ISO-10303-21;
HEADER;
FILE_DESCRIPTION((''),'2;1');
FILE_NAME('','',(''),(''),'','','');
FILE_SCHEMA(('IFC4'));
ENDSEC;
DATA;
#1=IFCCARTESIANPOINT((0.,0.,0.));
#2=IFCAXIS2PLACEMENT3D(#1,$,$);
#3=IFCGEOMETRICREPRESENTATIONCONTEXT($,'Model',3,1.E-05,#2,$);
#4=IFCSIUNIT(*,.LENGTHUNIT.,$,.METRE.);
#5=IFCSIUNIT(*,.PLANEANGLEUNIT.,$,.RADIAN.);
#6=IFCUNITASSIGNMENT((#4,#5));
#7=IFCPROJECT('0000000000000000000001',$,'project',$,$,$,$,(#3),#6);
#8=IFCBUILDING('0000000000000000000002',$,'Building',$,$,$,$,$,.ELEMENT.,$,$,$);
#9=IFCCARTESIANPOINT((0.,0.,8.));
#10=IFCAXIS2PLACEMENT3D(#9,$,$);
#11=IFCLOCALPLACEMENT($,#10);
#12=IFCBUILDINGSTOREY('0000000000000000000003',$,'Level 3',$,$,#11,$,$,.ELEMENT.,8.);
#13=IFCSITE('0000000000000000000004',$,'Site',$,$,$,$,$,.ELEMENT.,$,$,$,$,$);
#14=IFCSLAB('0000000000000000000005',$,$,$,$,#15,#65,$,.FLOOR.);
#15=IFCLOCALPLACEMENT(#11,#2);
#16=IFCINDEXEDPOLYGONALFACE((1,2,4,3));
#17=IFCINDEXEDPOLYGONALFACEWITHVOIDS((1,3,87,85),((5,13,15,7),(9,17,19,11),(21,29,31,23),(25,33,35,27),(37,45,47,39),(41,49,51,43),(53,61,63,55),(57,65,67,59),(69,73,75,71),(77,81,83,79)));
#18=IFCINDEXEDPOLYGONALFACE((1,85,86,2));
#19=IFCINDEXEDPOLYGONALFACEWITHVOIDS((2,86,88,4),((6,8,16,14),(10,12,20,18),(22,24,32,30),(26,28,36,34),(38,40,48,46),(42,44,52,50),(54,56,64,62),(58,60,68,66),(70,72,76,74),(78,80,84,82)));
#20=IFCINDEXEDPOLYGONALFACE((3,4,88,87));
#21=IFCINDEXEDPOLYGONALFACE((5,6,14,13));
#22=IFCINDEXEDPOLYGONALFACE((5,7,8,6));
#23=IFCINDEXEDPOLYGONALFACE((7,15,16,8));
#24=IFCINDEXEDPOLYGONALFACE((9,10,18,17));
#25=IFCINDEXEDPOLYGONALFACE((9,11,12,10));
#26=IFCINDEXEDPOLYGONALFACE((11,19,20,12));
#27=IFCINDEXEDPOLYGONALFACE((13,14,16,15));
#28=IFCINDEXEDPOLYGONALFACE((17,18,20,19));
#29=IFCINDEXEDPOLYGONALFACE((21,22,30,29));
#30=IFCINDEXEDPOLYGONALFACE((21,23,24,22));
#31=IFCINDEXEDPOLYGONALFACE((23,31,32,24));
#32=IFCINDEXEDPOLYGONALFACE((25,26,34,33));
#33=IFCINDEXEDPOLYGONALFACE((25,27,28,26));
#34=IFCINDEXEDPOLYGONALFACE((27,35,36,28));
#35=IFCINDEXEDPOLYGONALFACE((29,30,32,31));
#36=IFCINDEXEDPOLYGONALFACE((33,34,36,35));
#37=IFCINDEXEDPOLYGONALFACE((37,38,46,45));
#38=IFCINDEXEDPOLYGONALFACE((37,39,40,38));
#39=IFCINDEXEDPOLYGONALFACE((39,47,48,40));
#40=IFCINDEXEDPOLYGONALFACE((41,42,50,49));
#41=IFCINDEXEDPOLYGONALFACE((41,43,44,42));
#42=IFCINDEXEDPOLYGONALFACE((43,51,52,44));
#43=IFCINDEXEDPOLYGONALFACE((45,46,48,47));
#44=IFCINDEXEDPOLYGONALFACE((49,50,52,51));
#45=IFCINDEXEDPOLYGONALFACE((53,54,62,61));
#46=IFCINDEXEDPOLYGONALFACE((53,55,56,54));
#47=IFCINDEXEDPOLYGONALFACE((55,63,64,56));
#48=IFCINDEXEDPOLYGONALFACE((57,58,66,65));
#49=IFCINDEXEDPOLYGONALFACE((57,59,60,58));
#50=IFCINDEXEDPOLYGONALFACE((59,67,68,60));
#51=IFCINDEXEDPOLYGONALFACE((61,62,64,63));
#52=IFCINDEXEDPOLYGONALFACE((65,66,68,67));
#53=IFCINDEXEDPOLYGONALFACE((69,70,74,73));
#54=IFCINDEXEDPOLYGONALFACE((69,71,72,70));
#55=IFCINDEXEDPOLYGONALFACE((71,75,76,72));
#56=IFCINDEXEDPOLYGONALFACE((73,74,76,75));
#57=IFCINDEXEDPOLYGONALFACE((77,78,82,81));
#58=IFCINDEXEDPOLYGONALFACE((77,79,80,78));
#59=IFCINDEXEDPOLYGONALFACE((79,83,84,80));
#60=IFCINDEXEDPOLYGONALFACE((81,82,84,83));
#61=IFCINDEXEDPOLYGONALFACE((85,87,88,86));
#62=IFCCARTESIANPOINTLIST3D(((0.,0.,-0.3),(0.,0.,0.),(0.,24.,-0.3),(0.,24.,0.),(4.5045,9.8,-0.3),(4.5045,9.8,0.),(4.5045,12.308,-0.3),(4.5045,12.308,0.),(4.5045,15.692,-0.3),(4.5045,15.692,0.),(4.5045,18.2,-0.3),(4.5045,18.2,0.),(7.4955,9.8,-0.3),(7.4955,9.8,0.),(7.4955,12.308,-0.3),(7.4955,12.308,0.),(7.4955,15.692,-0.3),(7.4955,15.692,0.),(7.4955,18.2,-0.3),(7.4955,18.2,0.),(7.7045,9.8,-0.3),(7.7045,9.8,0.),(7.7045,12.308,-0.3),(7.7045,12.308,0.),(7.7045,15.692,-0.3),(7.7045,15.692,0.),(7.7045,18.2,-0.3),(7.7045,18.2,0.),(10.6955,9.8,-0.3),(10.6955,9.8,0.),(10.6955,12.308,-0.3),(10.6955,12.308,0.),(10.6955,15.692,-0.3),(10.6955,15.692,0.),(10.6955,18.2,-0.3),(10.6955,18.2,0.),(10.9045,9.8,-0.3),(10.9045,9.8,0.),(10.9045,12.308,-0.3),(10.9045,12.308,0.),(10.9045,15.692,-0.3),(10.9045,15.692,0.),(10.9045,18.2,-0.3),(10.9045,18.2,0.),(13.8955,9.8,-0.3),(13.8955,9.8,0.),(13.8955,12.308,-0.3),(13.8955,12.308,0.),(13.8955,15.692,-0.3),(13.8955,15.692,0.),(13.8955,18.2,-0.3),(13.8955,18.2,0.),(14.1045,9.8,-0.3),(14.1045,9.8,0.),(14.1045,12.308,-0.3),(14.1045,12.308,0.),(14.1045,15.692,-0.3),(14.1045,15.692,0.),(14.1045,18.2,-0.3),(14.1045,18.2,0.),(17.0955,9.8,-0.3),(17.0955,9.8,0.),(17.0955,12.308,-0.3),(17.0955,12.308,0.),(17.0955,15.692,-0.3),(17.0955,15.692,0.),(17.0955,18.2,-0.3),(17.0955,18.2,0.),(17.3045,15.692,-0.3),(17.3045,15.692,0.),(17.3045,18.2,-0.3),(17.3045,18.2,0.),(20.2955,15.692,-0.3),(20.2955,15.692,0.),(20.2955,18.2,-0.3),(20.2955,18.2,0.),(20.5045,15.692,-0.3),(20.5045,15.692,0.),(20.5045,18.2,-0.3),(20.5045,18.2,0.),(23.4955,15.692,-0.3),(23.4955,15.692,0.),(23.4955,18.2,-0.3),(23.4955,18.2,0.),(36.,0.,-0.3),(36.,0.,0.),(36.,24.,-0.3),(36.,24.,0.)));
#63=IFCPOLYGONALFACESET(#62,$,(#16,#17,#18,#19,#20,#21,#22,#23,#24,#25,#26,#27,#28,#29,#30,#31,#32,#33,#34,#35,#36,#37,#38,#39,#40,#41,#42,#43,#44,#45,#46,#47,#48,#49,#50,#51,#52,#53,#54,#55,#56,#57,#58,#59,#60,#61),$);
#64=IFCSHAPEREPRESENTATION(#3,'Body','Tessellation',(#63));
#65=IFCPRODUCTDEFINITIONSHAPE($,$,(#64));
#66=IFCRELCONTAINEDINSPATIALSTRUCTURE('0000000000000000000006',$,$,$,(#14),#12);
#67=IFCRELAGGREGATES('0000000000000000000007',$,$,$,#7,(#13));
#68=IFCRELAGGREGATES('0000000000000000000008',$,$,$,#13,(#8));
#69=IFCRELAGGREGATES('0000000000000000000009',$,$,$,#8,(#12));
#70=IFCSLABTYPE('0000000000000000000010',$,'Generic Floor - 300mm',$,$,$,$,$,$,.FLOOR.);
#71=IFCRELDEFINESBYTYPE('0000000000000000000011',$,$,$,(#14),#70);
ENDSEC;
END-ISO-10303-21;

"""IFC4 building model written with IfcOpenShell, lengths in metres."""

from ifc_helpers import new_model, si_unit, frame, origin, place, context, project, spatial, polyline, outline, extrude, type_object, element, save


model = new_model("IFC4")

# Units and contexts
model_context = context("Model", 3, precision=1e-05, world=origin())
ifc_project = project(units=[si_unit("LENGTHUNIT", "METRE"), si_unit("PLANEANGLEUNIT", "RADIAN")], contexts=[model_context])

# Site, building, storey
site = spatial("IfcSite", under=ifc_project, Name="Site", CompositionType="ELEMENT")
building = spatial("IfcBuilding", under=site, Name="Building", CompositionType="ELEMENT")
storey_placement = place(None, frame((0.0, 0.0, 8.0)))
storey = spatial("IfcBuildingStorey", under=building, at=storey_placement, Name="Level 3", CompositionType="ELEMENT", Elevation=8.0)

# Slab, openings
slab_type = type_object("IfcSlabType", Name="Generic Floor - 300mm", PredefinedType="FLOOR")
slab_placement = place(None, frame((0.0, 0.0, 8.0)))
slab = element("IfcSlab", 1, at=slab_placement, inside=storey, type_object=slab_type, PredefinedType="FLOOR", context=model_context, shape_type="SweptSolid", body=[
    extrude(outline(polyline([(0.0, 0.0), (36.0, 0.0), (36.0, 24.0), (0.0, 24.0), (0.0, 0.0)])), origin(), (0.0, 0.0, -1.0), 0.3),
])
opening_1_placement = place(None, frame((0.0, 0.0, 8.001)))
element("IfcOpeningElement", 2, at=opening_1_placement, cuts=slab, PredefinedType="OPENING", context=model_context, shape_type="SweptSolid", body=[
    extrude(outline(polyline([(4.5045, 9.8), (7.4955, 9.8), (7.4955, 12.308), (4.5045, 12.308), (4.5045, 9.8)])), origin(), (0.0, 0.0, -1.0), 0.302),
])
opening_2_placement = place(None, frame((0.0, 0.0, 8.001)))
element("IfcOpeningElement", 3, at=opening_2_placement, cuts=slab, PredefinedType="OPENING", context=model_context, shape_type="SweptSolid", body=[
    extrude(outline(polyline([(7.7045, 9.8), (10.6955, 9.8), (10.6955, 12.308), (7.7045, 12.308), (7.7045, 9.8)])), origin(), (0.0, 0.0, -1.0), 0.302),
])
opening_3_placement = place(None, frame((0.0, 0.0, 8.001)))
element("IfcOpeningElement", 4, at=opening_3_placement, cuts=slab, PredefinedType="OPENING", context=model_context, shape_type="SweptSolid", body=[
    extrude(outline(polyline([(10.9045, 9.8), (13.8955, 9.8), (13.8955, 12.308), (10.9045, 12.308), (10.9045, 9.8)])), origin(), (0.0, 0.0, -1.0), 0.302),
])
opening_4_placement = place(None, frame((0.0, 0.0, 8.001)))
element("IfcOpeningElement", 5, at=opening_4_placement, cuts=slab, PredefinedType="OPENING", context=model_context, shape_type="SweptSolid", body=[
    extrude(outline(polyline([(14.1045, 9.8), (17.0955, 9.8), (17.0955, 12.308), (14.1045, 12.308), (14.1045, 9.8)])), origin(), (0.0, 0.0, -1.0), 0.302),
])
opening_5_placement = place(None, frame((0.0, 0.0, 8.001)))
element("IfcOpeningElement", 6, at=opening_5_placement, cuts=slab, PredefinedType="OPENING", context=model_context, shape_type="SweptSolid", body=[
    extrude(outline(polyline([(7.4955, 18.2), (4.5045, 18.2), (4.5045, 15.692), (7.4955, 15.692), (7.4955, 18.2)])), origin(), (0.0, 0.0, -1.0), 0.302),
])
opening_6_placement = place(None, frame((0.0, 0.0, 8.001)))
element("IfcOpeningElement", 7, at=opening_6_placement, cuts=slab, PredefinedType="OPENING", context=model_context, shape_type="SweptSolid", body=[
    extrude(outline(polyline([(10.6955, 18.2), (7.7045, 18.2), (7.7045, 15.692), (10.6955, 15.692), (10.6955, 18.2)])), origin(), (0.0, 0.0, -1.0), 0.302),
])
opening_7_placement = place(None, frame((0.0, 0.0, 8.001)))
element("IfcOpeningElement", 8, at=opening_7_placement, cuts=slab, PredefinedType="OPENING", context=model_context, shape_type="SweptSolid", body=[
    extrude(outline(polyline([(13.8955, 18.2), (10.9045, 18.2), (10.9045, 15.692), (13.8955, 15.692), (13.8955, 18.2)])), origin(), (0.0, 0.0, -1.0), 0.302),
])
opening_8_placement = place(None, frame((0.0, 0.0, 8.001)))
element("IfcOpeningElement", 9, at=opening_8_placement, cuts=slab, PredefinedType="OPENING", context=model_context, shape_type="SweptSolid", body=[
    extrude(outline(polyline([(17.0955, 18.2), (14.1045, 18.2), (14.1045, 15.692), (17.0955, 15.692), (17.0955, 18.2)])), origin(), (0.0, 0.0, -1.0), 0.302),
])
opening_9_placement = place(None, frame((0.0, 0.0, 8.001)))
element("IfcOpeningElement", 10, at=opening_9_placement, cuts=slab, PredefinedType="OPENING", context=model_context, shape_type="SweptSolid", body=[
    extrude(outline(polyline([(20.2955, 18.2), (17.3045, 18.2), (17.3045, 15.692), (20.2955, 15.692), (20.2955, 18.2)])), origin(), (0.0, 0.0, -1.0), 0.302),
])
opening_10_placement = place(None, frame((0.0, 0.0, 8.001)))
element("IfcOpeningElement", 11, at=opening_10_placement, cuts=slab, PredefinedType="OPENING", context=model_context, shape_type="SweptSolid", body=[
    extrude(outline(polyline([(23.4955, 18.2), (20.5045, 18.2), (20.5045, 15.692), (23.4955, 15.692), (23.4955, 18.2)])), origin(), (0.0, 0.0, -1.0), 0.302),
])

save(model, "model.ifc")
